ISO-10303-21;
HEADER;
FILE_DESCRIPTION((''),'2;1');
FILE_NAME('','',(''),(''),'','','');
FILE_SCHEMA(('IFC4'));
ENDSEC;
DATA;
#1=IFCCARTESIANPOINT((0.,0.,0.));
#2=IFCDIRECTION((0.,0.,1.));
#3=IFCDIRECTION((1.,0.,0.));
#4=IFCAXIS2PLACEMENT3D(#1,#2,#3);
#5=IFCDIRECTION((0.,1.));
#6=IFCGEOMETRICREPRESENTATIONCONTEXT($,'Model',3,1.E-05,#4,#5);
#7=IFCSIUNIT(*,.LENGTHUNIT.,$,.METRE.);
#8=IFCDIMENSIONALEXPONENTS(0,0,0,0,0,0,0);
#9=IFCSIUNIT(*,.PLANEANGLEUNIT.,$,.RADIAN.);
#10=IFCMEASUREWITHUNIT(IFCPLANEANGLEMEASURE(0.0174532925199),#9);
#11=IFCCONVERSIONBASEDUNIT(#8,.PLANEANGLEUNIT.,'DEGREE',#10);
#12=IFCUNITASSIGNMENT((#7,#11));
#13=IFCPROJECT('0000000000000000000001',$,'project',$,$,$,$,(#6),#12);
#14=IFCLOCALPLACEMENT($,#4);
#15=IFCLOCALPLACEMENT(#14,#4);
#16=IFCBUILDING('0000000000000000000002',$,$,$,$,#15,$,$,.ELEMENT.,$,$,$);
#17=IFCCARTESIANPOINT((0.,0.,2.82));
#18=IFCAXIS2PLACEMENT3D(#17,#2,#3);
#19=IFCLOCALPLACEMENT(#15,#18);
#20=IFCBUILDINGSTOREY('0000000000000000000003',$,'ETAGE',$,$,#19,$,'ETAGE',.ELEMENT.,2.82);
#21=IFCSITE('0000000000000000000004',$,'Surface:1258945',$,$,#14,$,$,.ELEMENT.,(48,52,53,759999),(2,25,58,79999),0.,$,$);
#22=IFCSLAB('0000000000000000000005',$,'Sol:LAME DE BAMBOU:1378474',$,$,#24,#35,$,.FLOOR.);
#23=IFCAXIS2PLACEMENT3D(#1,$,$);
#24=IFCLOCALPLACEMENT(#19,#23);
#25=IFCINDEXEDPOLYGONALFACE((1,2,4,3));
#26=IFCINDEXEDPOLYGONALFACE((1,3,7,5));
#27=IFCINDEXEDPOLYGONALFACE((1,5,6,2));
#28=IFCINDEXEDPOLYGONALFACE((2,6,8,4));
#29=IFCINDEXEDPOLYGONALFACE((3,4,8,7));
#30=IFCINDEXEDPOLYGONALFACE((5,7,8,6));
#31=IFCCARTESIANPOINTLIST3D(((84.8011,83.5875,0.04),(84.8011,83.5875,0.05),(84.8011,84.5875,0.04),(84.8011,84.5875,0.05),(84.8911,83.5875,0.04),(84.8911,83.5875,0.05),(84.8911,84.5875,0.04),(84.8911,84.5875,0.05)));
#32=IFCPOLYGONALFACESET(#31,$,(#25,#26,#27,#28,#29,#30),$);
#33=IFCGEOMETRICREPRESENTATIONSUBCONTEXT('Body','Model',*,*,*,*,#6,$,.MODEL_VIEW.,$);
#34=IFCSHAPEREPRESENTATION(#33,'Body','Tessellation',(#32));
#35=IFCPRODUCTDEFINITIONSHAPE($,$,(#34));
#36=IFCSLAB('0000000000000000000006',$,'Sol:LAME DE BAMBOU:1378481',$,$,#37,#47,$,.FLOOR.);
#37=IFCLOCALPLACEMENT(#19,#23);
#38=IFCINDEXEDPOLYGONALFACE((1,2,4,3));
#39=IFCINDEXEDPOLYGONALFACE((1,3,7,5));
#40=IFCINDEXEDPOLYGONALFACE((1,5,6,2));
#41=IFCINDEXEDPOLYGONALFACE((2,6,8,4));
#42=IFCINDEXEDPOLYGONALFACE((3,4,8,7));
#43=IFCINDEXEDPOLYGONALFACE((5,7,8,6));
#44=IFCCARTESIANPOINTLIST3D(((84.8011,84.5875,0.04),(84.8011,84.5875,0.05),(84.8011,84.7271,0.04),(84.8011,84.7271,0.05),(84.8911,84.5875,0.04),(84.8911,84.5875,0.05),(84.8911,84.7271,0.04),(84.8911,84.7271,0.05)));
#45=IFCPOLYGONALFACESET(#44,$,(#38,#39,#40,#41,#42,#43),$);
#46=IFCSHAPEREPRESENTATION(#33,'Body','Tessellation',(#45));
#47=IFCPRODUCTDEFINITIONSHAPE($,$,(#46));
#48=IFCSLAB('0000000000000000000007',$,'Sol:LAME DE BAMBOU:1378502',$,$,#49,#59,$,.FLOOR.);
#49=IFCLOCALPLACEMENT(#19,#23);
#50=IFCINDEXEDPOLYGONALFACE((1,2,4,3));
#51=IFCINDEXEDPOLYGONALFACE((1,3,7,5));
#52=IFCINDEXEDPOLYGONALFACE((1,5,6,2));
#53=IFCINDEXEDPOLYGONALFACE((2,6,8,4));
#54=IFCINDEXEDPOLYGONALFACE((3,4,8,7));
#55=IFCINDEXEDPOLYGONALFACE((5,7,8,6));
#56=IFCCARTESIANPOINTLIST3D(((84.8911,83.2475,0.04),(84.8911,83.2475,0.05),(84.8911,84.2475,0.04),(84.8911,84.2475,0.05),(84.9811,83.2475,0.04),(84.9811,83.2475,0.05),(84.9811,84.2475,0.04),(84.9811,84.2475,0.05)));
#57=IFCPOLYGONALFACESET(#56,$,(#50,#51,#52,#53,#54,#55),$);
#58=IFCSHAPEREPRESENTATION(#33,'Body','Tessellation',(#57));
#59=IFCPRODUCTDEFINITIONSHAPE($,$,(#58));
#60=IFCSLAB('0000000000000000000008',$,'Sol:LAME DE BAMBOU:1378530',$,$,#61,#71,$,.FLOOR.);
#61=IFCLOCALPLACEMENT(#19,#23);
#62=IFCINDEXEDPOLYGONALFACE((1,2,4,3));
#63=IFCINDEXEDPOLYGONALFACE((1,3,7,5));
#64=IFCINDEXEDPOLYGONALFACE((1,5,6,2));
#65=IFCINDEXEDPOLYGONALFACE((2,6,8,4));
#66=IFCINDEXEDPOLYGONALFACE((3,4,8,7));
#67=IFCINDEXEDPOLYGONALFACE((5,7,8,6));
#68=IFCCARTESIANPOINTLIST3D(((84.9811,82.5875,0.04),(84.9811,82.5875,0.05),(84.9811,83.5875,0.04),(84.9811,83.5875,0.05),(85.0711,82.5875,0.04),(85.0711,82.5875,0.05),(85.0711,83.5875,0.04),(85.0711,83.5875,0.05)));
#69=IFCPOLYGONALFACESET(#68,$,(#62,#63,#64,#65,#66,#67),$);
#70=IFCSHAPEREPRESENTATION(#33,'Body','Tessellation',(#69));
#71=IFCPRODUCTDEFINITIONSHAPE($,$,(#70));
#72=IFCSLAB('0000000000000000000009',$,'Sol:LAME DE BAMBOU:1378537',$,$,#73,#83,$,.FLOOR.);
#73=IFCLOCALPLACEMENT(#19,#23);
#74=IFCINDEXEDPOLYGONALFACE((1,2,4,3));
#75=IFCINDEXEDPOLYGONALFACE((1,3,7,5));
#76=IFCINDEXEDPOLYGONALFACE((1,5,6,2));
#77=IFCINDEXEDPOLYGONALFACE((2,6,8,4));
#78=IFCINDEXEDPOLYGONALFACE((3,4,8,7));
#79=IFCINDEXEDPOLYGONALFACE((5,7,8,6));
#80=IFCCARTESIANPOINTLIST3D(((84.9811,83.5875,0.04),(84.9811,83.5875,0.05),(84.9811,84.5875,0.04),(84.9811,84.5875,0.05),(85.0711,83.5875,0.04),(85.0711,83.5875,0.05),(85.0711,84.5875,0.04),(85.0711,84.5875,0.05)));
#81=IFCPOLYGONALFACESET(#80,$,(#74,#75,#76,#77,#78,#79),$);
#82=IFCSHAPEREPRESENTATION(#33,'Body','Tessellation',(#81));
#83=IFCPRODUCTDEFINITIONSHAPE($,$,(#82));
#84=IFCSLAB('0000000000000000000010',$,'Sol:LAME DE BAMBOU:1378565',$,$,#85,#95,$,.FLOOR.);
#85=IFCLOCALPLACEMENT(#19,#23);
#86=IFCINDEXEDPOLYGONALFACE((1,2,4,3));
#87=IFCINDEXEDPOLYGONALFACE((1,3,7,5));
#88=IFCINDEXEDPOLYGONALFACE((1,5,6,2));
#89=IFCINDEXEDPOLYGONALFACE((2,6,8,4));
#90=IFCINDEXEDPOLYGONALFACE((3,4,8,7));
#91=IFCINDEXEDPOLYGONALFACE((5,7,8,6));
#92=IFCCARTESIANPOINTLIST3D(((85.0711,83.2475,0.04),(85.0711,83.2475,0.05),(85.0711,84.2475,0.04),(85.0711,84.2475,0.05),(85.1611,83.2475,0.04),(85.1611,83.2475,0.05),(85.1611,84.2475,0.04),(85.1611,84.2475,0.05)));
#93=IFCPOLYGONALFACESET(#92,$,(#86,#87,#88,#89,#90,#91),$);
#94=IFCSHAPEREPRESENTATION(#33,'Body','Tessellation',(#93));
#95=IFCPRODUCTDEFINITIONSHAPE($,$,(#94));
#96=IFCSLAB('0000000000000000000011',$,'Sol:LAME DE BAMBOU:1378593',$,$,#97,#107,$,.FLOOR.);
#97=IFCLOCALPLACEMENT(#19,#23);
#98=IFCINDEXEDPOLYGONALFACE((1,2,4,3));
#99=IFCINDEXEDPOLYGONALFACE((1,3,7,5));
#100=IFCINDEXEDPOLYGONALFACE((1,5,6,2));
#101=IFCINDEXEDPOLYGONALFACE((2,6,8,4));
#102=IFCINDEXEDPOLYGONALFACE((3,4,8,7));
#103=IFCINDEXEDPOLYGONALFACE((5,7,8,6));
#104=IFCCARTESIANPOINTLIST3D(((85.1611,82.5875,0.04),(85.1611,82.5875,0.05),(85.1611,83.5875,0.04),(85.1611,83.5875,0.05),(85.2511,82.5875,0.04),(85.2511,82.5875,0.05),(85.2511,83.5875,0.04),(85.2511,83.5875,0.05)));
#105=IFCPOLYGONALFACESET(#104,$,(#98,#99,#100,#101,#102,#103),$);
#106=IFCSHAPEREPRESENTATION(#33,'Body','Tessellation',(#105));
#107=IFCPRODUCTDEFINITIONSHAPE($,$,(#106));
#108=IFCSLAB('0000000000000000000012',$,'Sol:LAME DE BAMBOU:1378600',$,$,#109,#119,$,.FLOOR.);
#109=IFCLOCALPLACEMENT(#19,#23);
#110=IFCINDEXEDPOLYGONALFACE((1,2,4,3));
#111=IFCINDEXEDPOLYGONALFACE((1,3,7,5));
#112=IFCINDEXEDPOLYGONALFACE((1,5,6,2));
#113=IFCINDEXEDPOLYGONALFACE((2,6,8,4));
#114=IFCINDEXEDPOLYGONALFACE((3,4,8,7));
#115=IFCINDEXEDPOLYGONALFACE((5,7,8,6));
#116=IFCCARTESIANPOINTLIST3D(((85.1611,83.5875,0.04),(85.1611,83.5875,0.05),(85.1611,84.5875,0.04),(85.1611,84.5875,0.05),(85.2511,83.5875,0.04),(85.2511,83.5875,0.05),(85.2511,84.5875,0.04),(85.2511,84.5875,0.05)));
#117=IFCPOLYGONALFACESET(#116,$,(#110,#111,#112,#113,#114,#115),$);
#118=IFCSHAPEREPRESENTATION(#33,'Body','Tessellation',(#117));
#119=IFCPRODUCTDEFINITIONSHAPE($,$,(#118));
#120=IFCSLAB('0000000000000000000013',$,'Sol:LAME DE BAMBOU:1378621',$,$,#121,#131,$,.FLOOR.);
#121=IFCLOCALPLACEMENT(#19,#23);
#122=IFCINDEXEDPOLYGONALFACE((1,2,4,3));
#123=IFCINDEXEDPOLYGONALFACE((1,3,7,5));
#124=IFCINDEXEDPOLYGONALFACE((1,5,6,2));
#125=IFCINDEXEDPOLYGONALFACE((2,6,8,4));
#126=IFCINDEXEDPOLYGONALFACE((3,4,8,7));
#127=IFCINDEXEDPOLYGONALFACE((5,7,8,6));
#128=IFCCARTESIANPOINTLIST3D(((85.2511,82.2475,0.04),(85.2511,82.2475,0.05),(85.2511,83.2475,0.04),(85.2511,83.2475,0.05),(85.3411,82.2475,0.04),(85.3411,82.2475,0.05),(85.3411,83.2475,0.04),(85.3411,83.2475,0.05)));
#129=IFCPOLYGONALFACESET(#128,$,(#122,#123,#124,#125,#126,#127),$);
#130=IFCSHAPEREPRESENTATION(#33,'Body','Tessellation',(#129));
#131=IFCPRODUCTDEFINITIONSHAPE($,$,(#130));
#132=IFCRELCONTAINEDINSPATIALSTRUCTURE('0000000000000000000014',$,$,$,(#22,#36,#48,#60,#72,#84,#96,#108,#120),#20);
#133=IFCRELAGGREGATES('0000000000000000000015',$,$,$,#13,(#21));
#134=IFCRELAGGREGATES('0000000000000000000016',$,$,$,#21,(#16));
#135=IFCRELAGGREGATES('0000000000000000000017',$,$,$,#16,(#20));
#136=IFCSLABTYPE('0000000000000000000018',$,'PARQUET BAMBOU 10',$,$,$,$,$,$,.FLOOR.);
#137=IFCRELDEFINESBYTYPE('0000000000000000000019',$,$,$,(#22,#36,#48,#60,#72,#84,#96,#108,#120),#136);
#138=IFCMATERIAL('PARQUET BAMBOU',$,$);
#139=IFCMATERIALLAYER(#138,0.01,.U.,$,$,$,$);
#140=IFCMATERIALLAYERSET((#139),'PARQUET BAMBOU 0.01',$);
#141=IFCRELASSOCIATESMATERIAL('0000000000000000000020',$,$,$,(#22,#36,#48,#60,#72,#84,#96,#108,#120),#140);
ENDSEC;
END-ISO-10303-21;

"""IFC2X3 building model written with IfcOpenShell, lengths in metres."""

from ifc_helpers import new_model, entity, si_unit, converted_unit, direction, frame, origin_with_axes, place, context, subcontext, project, spatial, polyline, outline, extrude, material, layer, layer_set, layer_usage, type_object, element, save


model = new_model("IFC2X3")

# Units and contexts
model_context = context("Model", 3, precision=1e-05, world=origin_with_axes(), true_north=direction((0.0, 1.0)))
body_context = subcontext(model_context, "Body", "Model", "MODEL_VIEW")
ifc_project = project(units=[si_unit("LENGTHUNIT", "METRE"), converted_unit("PLANEANGLEUNIT", "DEGREE", entity("IfcPlaneAngleMeasure", 0.0174532925199), si_unit("PLANEANGLEUNIT", "RADIAN"), dimensions=[0, 0, 0, 0, 0, 0, 0])], contexts=[model_context])

# Site, building, storey
site_placement = place(None, origin_with_axes())
site = spatial("IfcSite", under=ifc_project, at=site_placement, Name="Surface:1258945", CompositionType="ELEMENT", RefLatitude=(48, 52, 53, 759999), RefLongitude=(2, 25, 58, 79999), RefElevation=0.0)
building_placement = place(site_placement, origin_with_axes())
building = spatial("IfcBuilding", under=site, at=building_placement, CompositionType="ELEMENT")
storey_placement = place(building_placement, frame((0.0, 0.0, 2.82), z_axis=(0.0, 0.0, 1.0), x_axis=(1.0, 0.0, 0.0)))
storey = spatial("IfcBuildingStorey", under=building, at=storey_placement, Name="ETAGE", LongName="ETAGE", CompositionType="ELEMENT", Elevation=2.82)

# Slabs
ifc_material = material(Name="PARQUET BAMBOU")
ifc_layer = layer(ifc_material, 0.01, ventilated="UNKNOWN")
ifc_layer_set = layer_set([ifc_layer], Name="PARQUET BAMBOU 0.01")
slab_type = type_object("IfcSlabType", Name="PARQUET BAMBOU 10", PredefinedType="FLOOR")
ifc_layer_usage_1 = layer_usage(ifc_layer_set, "AXIS3", "NEGATIVE", 0.01)
slab_1_placement = place(storey_placement, frame((84.8011, 84.5875, 0.05), z_axis=(0.0, 0.0, 1.0), x_axis=(1.0, 0.0, 0.0)))
element("IfcSlab", 1, at=slab_1_placement, inside=storey, type_object=slab_type, material=ifc_layer_usage_1, Name="Sol:LAME DE BAMBOU:1378474", PredefinedType="FLOOR", context=body_context, shape_type="SweptSolid", body=[
    extrude(outline(polyline([(0.0, 0.0), (0.0, -1.0), (0.09, -1.0), (0.09, 0.0), (0.0, 0.0)])), frame((0.0, 0.0, -0.01), z_axis=(0.0, 0.0, 1.0), x_axis=(1.0, 0.0, 0.0)), (0.0, 0.0, 1.0), 0.01),
])
ifc_layer_usage_2 = layer_usage(ifc_layer_set, "AXIS3", "NEGATIVE", 0.01)
slab_2_placement = place(storey_placement, frame((84.8011, 84.7271, 0.05), z_axis=(0.0, 0.0, 1.0), x_axis=(1.0, 0.0, 0.0)))
element("IfcSlab", 2, at=slab_2_placement, inside=storey, type_object=slab_type, material=ifc_layer_usage_2, Name="Sol:LAME DE BAMBOU:1378481", PredefinedType="FLOOR", context=body_context, shape_type="SweptSolid", body=[
    extrude(outline(polyline([(0.0, 0.0), (0.0, -0.1396), (0.09, -0.1396), (0.09, 0.0), (0.0, 0.0)])), frame((0.0, 0.0, -0.01), z_axis=(0.0, 0.0, 1.0), x_axis=(1.0, 0.0, 0.0)), (0.0, 0.0, 1.0), 0.01),
])
ifc_layer_usage_3 = layer_usage(ifc_layer_set, "AXIS3", "NEGATIVE", 0.01)
slab_3_placement = place(storey_placement, frame((84.8911, 84.2475, 0.05), z_axis=(0.0, 0.0, 1.0), x_axis=(1.0, 0.0, 0.0)))
element("IfcSlab", 3, at=slab_3_placement, inside=storey, type_object=slab_type, material=ifc_layer_usage_3, Name="Sol:LAME DE BAMBOU:1378502", PredefinedType="FLOOR", context=body_context, shape_type="SweptSolid", body=[
    extrude(outline(polyline([(0.0, 0.0), (0.0, -1.0), (0.09, -1.0), (0.09, 0.0), (0.0, 0.0)])), frame((0.0, 0.0, -0.01), z_axis=(0.0, 0.0, 1.0), x_axis=(1.0, 0.0, 0.0)), (0.0, 0.0, 1.0), 0.01),
])
ifc_layer_usage_4 = layer_usage(ifc_layer_set, "AXIS3", "NEGATIVE", 0.01)
slab_4_placement = place(storey_placement, frame((84.9811, 83.5875, 0.05), z_axis=(0.0, 0.0, 1.0), x_axis=(1.0, 0.0, 0.0)))
element("IfcSlab", 4, at=slab_4_placement, inside=storey, type_object=slab_type, material=ifc_layer_usage_4, Name="Sol:LAME DE BAMBOU:1378530", PredefinedType="FLOOR", context=body_context, shape_type="SweptSolid", body=[
    extrude(outline(polyline([(0.0, 0.0), (0.0, -1.0), (0.09, -1.0), (0.09, 0.0), (0.0, 0.0)])), frame((0.0, 0.0, -0.01), z_axis=(0.0, 0.0, 1.0), x_axis=(1.0, 0.0, 0.0)), (0.0, 0.0, 1.0), 0.01),
])
ifc_layer_usage_5 = layer_usage(ifc_layer_set, "AXIS3", "NEGATIVE", 0.01)
slab_5_placement = place(storey_placement, frame((84.9811, 84.5875, 0.05), z_axis=(0.0, 0.0, 1.0), x_axis=(1.0, 0.0, 0.0)))
element("IfcSlab", 5, at=slab_5_placement, inside=storey, type_object=slab_type, material=ifc_layer_usage_5, Name="Sol:LAME DE BAMBOU:1378537", PredefinedType="FLOOR", context=body_context, shape_type="SweptSolid", body=[
    extrude(outline(polyline([(0.0, 0.0), (0.0, -1.0), (0.09, -1.0), (0.09, 0.0), (0.0, 0.0)])), frame((0.0, 0.0, -0.01), z_axis=(0.0, 0.0, 1.0), x_axis=(1.0, 0.0, 0.0)), (0.0, 0.0, 1.0), 0.01),
])
ifc_layer_usage_6 = layer_usage(ifc_layer_set, "AXIS3", "NEGATIVE", 0.01)
slab_6_placement = place(storey_placement, frame((85.0711, 84.2475, 0.05), z_axis=(0.0, 0.0, 1.0), x_axis=(1.0, 0.0, 0.0)))
element("IfcSlab", 6, at=slab_6_placement, inside=storey, type_object=slab_type, material=ifc_layer_usage_6, Name="Sol:LAME DE BAMBOU:1378565", PredefinedType="FLOOR", context=body_context, shape_type="SweptSolid", body=[
    extrude(outline(polyline([(0.0, 0.0), (0.0, -1.0), (0.09, -1.0), (0.09, 0.0), (0.0, 0.0)])), frame((0.0, 0.0, -0.01), z_axis=(0.0, 0.0, 1.0), x_axis=(1.0, 0.0, 0.0)), (0.0, 0.0, 1.0), 0.01),
])
ifc_layer_usage_7 = layer_usage(ifc_layer_set, "AXIS3", "NEGATIVE", 0.01)
slab_7_placement = place(storey_placement, frame((85.1611, 83.5875, 0.05), z_axis=(0.0, 0.0, 1.0), x_axis=(1.0, 0.0, 0.0)))
element("IfcSlab", 7, at=slab_7_placement, inside=storey, type_object=slab_type, material=ifc_layer_usage_7, Name="Sol:LAME DE BAMBOU:1378593", PredefinedType="FLOOR", context=body_context, shape_type="SweptSolid", body=[
    extrude(outline(polyline([(0.0, 0.0), (0.0, -1.0), (0.09, -1.0), (0.09, 0.0), (0.0, 0.0)])), frame((0.0, 0.0, -0.01), z_axis=(0.0, 0.0, 1.0), x_axis=(1.0, 0.0, 0.0)), (0.0, 0.0, 1.0), 0.01),
])
ifc_layer_usage_8 = layer_usage(ifc_layer_set, "AXIS3", "NEGATIVE", 0.01)
slab_8_placement = place(storey_placement, frame((85.1611, 84.5875, 0.05), z_axis=(0.0, 0.0, 1.0), x_axis=(1.0, 0.0, 0.0)))
element("IfcSlab", 8, at=slab_8_placement, inside=storey, type_object=slab_type, material=ifc_layer_usage_8, Name="Sol:LAME DE BAMBOU:1378600", PredefinedType="FLOOR", context=body_context, shape_type="SweptSolid", body=[
    extrude(outline(polyline([(0.0, 0.0), (0.0, -1.0), (0.09, -1.0), (0.09, 0.0), (0.0, 0.0)])), frame((0.0, 0.0, -0.01), z_axis=(0.0, 0.0, 1.0), x_axis=(1.0, 0.0, 0.0)), (0.0, 0.0, 1.0), 0.01),
])
ifc_layer_usage_9 = layer_usage(ifc_layer_set, "AXIS3", "NEGATIVE", 0.01)
slab_9_placement = place(storey_placement, frame((85.2511, 83.2475, 0.05), z_axis=(0.0, 0.0, 1.0), x_axis=(1.0, 0.0, 0.0)))
element("IfcSlab", 9, at=slab_9_placement, inside=storey, type_object=slab_type, material=ifc_layer_usage_9, Name="Sol:LAME DE BAMBOU:1378621", PredefinedType="FLOOR", context=body_context, shape_type="SweptSolid", body=[
    extrude(outline(polyline([(0.0, 0.0), (0.0, -1.0), (0.09, -1.0), (0.09, 0.0), (0.0, 0.0)])), frame((0.0, 0.0, -0.01), z_axis=(0.0, 0.0, 1.0), x_axis=(1.0, 0.0, 0.0)), (0.0, 0.0, 1.0), 0.01),
])

save(model, "model.ifc")
